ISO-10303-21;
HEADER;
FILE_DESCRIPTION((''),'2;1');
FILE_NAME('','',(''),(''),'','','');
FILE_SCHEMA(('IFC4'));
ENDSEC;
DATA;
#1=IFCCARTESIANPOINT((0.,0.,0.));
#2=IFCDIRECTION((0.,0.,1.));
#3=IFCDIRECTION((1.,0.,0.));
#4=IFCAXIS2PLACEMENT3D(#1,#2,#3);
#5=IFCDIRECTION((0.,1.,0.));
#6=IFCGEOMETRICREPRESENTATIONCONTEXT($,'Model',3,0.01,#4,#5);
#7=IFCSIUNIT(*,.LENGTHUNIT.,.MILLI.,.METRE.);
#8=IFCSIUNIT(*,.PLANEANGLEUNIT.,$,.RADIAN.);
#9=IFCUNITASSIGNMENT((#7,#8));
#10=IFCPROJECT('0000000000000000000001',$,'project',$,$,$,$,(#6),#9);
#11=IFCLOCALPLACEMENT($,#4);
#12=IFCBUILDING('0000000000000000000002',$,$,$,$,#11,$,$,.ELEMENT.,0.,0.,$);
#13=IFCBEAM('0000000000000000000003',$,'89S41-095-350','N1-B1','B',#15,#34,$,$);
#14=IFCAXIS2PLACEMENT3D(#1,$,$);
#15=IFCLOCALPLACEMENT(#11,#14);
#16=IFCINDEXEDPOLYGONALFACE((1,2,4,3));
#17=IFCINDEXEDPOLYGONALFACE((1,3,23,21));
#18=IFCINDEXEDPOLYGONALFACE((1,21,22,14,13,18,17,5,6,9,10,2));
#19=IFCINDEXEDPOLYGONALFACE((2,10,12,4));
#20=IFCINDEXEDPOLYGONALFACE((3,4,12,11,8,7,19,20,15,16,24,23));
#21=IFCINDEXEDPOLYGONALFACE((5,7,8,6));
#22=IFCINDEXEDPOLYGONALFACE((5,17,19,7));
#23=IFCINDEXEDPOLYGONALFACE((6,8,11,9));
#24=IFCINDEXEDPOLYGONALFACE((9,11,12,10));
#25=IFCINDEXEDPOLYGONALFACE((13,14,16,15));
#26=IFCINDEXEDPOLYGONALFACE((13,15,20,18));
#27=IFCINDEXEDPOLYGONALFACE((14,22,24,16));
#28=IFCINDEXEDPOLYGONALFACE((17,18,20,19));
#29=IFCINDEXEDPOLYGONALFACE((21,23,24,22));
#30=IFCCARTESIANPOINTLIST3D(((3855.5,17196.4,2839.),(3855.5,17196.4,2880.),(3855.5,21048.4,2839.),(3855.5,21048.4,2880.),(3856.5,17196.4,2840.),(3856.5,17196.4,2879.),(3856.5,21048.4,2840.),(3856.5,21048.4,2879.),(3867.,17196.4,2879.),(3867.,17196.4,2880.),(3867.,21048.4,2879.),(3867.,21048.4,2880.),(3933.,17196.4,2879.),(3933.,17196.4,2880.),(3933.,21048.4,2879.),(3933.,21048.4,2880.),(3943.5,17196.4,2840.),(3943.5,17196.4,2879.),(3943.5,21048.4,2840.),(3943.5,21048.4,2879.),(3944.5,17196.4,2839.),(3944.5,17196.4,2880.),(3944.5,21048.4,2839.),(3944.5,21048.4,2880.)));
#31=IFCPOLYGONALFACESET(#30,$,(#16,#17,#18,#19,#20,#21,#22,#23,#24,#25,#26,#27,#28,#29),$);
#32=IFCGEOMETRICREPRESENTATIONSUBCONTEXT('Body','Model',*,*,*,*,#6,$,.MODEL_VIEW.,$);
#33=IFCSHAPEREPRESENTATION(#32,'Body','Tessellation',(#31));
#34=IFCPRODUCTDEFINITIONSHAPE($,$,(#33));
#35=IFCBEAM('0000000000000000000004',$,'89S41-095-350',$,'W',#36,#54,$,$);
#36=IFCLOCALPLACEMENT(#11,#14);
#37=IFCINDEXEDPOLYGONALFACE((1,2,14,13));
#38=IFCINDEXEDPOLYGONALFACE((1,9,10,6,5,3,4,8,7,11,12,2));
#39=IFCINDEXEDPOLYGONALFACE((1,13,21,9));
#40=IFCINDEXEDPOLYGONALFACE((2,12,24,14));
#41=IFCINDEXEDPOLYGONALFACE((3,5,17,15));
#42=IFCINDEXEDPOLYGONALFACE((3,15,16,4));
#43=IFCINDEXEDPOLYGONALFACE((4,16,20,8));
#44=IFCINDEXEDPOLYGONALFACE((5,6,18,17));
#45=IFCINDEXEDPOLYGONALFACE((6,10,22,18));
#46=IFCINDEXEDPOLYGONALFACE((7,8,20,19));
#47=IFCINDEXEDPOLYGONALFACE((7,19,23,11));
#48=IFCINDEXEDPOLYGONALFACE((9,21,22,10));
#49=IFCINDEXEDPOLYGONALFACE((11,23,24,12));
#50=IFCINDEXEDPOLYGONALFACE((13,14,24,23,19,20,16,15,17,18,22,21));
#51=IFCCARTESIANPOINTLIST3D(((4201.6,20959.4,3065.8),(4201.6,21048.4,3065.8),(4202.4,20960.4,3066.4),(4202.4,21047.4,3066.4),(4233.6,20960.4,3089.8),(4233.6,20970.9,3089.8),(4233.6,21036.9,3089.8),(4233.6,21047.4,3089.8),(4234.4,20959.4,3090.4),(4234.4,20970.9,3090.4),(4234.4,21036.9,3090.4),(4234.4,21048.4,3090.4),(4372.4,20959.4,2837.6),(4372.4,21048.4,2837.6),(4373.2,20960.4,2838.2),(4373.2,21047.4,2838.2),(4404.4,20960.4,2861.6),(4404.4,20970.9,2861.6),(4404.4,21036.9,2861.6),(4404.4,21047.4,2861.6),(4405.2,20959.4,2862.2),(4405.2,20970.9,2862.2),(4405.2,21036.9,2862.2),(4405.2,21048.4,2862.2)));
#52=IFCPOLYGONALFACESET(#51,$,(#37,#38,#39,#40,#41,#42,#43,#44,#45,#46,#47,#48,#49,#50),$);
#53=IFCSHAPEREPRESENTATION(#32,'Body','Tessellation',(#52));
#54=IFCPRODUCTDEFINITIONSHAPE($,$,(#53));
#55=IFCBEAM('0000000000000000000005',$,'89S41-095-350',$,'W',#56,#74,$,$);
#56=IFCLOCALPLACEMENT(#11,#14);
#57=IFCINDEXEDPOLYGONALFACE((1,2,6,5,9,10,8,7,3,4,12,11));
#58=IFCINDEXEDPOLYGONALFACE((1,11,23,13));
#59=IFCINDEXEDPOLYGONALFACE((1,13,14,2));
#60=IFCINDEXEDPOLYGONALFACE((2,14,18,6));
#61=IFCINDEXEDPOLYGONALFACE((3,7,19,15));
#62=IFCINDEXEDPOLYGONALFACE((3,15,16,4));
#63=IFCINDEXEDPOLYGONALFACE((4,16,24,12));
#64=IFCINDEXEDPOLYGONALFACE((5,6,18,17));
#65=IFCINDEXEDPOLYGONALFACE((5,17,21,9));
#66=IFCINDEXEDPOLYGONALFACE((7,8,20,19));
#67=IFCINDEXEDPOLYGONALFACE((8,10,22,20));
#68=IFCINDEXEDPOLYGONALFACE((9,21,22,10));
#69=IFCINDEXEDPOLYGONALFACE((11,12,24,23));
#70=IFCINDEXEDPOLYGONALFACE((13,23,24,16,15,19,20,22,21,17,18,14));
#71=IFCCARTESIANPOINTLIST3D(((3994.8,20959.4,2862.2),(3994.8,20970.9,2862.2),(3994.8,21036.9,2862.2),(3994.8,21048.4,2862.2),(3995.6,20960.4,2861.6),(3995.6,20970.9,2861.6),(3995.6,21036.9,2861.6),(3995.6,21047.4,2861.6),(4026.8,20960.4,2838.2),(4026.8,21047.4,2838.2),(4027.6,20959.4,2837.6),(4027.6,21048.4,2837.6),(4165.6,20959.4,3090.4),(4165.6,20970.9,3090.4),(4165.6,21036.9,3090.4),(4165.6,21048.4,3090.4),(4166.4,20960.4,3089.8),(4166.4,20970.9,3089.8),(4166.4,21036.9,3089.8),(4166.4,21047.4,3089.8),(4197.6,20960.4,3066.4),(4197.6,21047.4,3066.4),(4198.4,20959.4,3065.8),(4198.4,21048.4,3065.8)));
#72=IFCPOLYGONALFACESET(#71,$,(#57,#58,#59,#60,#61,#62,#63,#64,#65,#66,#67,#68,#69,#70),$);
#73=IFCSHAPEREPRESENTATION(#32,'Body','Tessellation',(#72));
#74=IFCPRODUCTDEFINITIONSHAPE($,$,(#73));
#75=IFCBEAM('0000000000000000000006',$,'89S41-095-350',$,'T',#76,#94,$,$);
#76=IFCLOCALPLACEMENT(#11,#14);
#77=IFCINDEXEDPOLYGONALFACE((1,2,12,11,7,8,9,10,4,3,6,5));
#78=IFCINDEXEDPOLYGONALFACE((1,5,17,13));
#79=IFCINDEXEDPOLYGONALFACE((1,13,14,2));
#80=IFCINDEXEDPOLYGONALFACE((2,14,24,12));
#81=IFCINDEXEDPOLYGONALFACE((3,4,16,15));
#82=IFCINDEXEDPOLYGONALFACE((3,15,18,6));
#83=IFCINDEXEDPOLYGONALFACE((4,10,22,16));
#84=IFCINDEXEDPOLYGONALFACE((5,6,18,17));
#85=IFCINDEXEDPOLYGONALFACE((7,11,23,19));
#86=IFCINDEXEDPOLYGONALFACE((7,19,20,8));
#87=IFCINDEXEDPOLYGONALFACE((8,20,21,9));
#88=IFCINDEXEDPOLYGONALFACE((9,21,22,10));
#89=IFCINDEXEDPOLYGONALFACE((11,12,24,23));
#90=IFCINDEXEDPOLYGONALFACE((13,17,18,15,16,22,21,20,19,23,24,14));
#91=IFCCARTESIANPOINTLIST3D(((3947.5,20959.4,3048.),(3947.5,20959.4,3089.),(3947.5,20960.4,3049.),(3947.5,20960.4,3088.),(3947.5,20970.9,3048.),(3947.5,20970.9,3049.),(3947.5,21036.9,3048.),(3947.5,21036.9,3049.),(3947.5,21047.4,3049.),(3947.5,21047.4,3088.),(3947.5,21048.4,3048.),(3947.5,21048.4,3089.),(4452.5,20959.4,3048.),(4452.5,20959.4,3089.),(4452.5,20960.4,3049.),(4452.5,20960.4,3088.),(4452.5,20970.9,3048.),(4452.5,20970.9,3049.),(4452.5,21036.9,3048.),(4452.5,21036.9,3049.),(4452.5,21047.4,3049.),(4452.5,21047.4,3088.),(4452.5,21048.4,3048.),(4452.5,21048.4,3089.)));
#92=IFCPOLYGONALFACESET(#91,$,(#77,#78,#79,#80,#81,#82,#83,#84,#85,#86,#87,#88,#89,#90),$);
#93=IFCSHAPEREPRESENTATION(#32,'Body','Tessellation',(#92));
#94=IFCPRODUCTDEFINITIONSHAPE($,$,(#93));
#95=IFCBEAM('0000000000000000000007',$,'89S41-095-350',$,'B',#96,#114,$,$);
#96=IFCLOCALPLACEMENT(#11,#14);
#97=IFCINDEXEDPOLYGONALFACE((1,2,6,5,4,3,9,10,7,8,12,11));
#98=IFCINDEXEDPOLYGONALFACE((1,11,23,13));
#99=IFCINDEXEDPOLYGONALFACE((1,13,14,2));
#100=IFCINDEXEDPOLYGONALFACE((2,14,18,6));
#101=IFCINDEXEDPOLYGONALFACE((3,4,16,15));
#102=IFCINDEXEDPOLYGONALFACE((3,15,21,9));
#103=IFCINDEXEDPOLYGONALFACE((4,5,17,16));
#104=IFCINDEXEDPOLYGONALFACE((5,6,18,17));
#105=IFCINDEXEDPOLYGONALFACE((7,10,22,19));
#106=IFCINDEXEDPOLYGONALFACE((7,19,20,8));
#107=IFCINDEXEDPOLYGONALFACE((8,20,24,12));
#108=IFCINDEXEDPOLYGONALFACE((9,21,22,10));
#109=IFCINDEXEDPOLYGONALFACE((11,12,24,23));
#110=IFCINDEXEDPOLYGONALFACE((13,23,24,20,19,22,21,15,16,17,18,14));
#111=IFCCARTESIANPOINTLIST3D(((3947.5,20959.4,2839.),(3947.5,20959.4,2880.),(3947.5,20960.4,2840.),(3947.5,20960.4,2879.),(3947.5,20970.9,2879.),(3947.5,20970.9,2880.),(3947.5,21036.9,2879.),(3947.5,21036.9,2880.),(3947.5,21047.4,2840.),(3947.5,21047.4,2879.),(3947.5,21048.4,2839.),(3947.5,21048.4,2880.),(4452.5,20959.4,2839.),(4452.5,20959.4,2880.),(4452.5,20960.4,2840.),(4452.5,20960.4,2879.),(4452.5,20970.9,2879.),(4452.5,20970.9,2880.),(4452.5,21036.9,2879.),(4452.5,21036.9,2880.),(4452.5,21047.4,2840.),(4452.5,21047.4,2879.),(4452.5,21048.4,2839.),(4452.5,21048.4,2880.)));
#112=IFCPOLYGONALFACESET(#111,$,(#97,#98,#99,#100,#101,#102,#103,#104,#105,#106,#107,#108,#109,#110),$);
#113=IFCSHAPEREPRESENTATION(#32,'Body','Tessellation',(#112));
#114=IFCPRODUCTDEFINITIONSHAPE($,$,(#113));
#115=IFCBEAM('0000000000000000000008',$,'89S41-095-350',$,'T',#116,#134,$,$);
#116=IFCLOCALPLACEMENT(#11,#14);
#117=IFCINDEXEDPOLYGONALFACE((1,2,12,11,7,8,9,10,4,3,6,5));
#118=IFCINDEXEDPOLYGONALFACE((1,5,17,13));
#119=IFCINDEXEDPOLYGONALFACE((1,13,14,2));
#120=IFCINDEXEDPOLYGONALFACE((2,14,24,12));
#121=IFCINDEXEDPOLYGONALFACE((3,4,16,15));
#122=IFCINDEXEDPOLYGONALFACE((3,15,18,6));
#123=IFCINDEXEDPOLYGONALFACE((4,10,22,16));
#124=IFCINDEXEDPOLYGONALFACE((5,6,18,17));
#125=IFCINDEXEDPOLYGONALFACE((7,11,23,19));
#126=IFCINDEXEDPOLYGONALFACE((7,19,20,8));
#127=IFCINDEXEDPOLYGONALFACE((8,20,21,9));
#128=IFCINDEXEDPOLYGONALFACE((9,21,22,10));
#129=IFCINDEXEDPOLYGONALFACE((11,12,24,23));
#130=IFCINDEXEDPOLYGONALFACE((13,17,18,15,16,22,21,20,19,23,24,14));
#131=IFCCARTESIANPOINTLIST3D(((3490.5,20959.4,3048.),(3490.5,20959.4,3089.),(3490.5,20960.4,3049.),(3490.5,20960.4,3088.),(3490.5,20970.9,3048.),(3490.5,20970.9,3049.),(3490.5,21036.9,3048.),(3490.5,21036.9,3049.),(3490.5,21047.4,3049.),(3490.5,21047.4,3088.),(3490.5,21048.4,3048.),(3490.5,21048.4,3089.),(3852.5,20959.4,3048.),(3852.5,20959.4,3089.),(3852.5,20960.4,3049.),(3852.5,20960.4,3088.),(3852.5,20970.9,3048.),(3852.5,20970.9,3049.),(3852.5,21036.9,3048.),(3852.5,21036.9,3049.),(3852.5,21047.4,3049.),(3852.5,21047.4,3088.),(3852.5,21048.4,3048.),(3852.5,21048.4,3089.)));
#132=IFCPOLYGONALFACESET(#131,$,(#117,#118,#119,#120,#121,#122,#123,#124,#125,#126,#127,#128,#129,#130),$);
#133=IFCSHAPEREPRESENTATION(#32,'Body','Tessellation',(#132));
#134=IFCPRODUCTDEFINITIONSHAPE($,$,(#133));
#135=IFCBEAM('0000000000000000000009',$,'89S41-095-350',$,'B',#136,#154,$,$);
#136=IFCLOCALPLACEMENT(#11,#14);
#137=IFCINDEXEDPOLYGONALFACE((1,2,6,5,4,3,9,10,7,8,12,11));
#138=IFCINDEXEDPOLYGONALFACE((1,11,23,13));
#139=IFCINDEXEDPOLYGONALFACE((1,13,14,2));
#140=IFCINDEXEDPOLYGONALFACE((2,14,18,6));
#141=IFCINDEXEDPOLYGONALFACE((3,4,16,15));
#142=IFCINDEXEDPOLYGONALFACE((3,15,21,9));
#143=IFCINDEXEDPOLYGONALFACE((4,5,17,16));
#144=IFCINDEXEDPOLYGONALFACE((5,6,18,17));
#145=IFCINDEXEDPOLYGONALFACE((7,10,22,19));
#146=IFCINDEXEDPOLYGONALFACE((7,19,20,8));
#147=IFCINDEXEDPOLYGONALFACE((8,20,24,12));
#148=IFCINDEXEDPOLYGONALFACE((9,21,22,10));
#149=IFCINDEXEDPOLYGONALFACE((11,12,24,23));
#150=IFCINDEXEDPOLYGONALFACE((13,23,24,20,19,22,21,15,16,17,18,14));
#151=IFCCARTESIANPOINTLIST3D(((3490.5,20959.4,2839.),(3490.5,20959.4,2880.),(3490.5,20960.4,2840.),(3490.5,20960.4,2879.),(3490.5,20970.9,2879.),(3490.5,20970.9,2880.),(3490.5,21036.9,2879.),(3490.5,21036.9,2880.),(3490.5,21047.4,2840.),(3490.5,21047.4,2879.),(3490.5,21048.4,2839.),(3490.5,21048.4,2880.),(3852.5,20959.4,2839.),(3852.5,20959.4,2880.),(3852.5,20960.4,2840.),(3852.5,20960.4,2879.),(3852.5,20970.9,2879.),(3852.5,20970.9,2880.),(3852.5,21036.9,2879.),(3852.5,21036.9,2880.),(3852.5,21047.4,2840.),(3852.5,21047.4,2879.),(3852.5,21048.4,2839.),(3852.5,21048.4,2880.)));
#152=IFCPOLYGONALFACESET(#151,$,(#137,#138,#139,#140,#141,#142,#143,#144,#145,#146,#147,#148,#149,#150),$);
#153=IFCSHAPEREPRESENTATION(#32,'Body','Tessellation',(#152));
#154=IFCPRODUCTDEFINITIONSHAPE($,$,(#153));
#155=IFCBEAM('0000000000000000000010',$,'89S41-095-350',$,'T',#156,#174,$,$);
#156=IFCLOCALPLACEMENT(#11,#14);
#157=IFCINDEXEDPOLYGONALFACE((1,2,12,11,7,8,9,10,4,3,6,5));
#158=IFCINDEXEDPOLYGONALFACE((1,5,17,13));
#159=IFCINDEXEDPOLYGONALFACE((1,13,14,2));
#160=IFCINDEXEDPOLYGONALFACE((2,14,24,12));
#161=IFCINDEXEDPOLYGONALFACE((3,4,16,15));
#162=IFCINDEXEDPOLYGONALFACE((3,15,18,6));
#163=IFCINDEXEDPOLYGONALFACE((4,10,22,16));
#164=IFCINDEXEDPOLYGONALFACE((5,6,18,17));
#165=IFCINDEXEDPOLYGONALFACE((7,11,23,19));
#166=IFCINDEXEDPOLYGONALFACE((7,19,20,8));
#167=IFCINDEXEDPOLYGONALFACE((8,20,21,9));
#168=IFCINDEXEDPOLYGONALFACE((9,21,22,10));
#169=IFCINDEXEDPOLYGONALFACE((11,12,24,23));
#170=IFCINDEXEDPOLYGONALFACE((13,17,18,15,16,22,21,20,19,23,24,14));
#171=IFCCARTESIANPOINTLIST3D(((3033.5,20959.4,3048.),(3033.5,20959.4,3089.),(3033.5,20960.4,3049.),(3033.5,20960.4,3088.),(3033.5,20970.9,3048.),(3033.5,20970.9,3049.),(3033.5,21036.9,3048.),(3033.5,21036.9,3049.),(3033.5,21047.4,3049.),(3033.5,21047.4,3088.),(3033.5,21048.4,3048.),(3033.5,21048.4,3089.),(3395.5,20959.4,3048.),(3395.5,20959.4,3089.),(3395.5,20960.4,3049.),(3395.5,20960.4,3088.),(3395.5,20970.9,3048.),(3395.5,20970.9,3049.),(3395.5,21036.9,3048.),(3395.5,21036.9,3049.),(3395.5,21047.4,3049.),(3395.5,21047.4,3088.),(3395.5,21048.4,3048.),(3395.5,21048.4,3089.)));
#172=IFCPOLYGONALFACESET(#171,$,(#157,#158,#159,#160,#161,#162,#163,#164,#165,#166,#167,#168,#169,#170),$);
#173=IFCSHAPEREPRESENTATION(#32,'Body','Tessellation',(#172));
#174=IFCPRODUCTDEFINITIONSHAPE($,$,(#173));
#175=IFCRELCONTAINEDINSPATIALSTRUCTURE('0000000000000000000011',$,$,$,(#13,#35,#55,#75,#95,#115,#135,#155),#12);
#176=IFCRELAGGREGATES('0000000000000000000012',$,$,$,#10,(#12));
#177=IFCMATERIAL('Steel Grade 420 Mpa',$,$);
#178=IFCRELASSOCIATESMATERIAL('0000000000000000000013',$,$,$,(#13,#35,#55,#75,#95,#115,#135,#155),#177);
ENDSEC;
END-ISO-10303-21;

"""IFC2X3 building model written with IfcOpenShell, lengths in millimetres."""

from ifc_helpers import new_model, si_unit, direction, frame, origin, origin_with_axes, origin_2d_with_axis, place, context, subcontext, project, spatial, c_section, extrude, source, transform, mapped, material, element, save


model = new_model("IFC2X3")

# Units and contexts
model_context = context("Model", 3, precision=0.01, world=origin_with_axes(), true_north=direction((0.0, 1.0, 0.0)))
body_context = subcontext(model_context, "Body", "Model", "MODEL_VIEW")
ifc_project = project(units=[si_unit("LENGTHUNIT", "METRE", prefix="MILLI"), si_unit("PLANEANGLEUNIT", "RADIAN")], contexts=[model_context])

# Building
building_placement = place(None, origin_with_axes())
building = spatial("IfcBuilding", under=ifc_project, at=building_placement, CompositionType="ELEMENT", ElevationOfRefHeight=0.0, ElevationOfTerrain=0.0)

# Shared definitions
ifc_material = material(Name="Steel Grade 420 Mpa")

# Beams
shared_shape_1 = source(origin(), body_context, "Body", "SweptSolid", [
    extrude(c_section(Depth=89.0, Width=41.0, WallThickness=1.0, Girth=11.5, at=origin_2d_with_axis()), origin_with_axes(), (0.0, 0.0, 1.0), 3852.0),
])
beam_1_placement = place(None, frame((3900.0, 21048.4, 2859.5), z_axis=(0.0, -1.0, 0.0), x_axis=(0.0, 0.0, 1.0)))
element("IfcBeam", 1, at=beam_1_placement, inside=building, material=ifc_material, Name="89S41-095-350", Description="N1-B1", ObjectType="B", context=body_context, shape_type="MappedRepresentation", body=[
    mapped(shared_shape_1, transform((0.0, 0.0, 0.0), scale=1.0)),
])
shared_shape_2 = source(origin(), body_context, "Body", "SweptSolid", [
    extrude(c_section(Depth=89.0, Width=41.0, WallThickness=1.0, Girth=11.5, at=origin_2d_with_axis()), origin_with_axes(), (0.0, 0.0, 1.0), 285.1),
])
beam_2_placement = place(None, frame((4218.0, 21003.9, 3078.1), z_axis=(0.599182, 0.0, -0.800613), x_axis=(0.800613, 0.0, 0.599182)))
element("IfcBeam", 2, at=beam_2_placement, inside=building, material=ifc_material, Name="89S41-095-350", ObjectType="W", context=body_context, shape_type="MappedRepresentation", body=[
    mapped(shared_shape_2, transform((0.0, 0.0, 0.0), scale=1.0)),
])
shared_shape_3 = source(origin(), body_context, "Body", "SweptSolid", [
    extrude(c_section(Depth=89.0, Width=41.0, WallThickness=1.0, Girth=11.5, at=origin_2d_with_axis()), origin_with_axes(), (0.0, 0.0, 1.0), 285.1),
])
beam_3_placement = place(None, frame((4011.2, 21003.9, 2849.9), z_axis=(0.599182, 0.0, 0.800613), x_axis=(-0.800613, 0.0, 0.599182)))
element("IfcBeam", 3, at=beam_3_placement, inside=building, material=ifc_material, Name="89S41-095-350", ObjectType="W", context=body_context, shape_type="MappedRepresentation", body=[
    mapped(shared_shape_3, transform((0.0, 0.0, 0.0), scale=1.0)),
])
shared_shape_4 = source(origin(), body_context, "Body", "SweptSolid", [
    extrude(c_section(Depth=89.0, Width=41.0, WallThickness=1.0, Girth=11.5, at=origin_2d_with_axis()), origin_with_axes(), (0.0, 0.0, 1.0), 505.0),
])
beam_4_placement = place(None, frame((4452.5, 21003.9, 3068.5), z_axis=(-1.0, 0.0, 0.0), x_axis=(0.0, 0.0, -1.0)))
element("IfcBeam", 4, at=beam_4_placement, inside=building, material=ifc_material, Name="89S41-095-350", ObjectType="T", context=body_context, shape_type="MappedRepresentation", body=[
    mapped(shared_shape_4, transform((0.0, 0.0, 0.0), scale=1.0)),
])
shared_shape_5 = source(origin(), body_context, "Body", "SweptSolid", [
    extrude(c_section(Depth=89.0, Width=41.0, WallThickness=1.0, Girth=11.5, at=origin_2d_with_axis()), origin_with_axes(), (0.0, 0.0, 1.0), 505.0),
])
beam_5_placement = place(None, frame((3947.5, 21003.9, 2859.5), z_axis=(1.0, 0.0, 0.0), x_axis=(0.0, 0.0, 1.0)))
element("IfcBeam", 5, at=beam_5_placement, inside=building, material=ifc_material, Name="89S41-095-350", ObjectType="B", context=body_context, shape_type="MappedRepresentation", body=[
    mapped(shared_shape_5, transform((0.0, 0.0, 0.0), scale=1.0)),
])
shared_shape_6 = source(origin(), body_context, "Body", "SweptSolid", [
    extrude(c_section(Depth=89.0, Width=41.0, WallThickness=1.0, Girth=11.5, at=origin_2d_with_axis()), origin_with_axes(), (0.0, 0.0, 1.0), 362.0),
])
beam_6_placement = place(None, frame((3852.5, 21003.9, 3068.5), z_axis=(-1.0, 0.0, 0.0), x_axis=(0.0, 0.0, -1.0)))
element("IfcBeam", 6, at=beam_6_placement, inside=building, material=ifc_material, Name="89S41-095-350", ObjectType="T", context=body_context, shape_type="MappedRepresentation", body=[
    mapped(shared_shape_6, transform((0.0, 0.0, 0.0), scale=1.0)),
])
shared_shape_7 = source(origin(), body_context, "Body", "SweptSolid", [
    extrude(c_section(Depth=89.0, Width=41.0, WallThickness=1.0, Girth=11.5, at=origin_2d_with_axis()), origin_with_axes(), (0.0, 0.0, 1.0), 362.0),
])
beam_7_placement = place(None, frame((3490.5, 21003.9, 2859.5), z_axis=(1.0, 0.0, 0.0), x_axis=(0.0, 0.0, 1.0)))
element("IfcBeam", 7, at=beam_7_placement, inside=building, material=ifc_material, Name="89S41-095-350", ObjectType="B", context=body_context, shape_type="MappedRepresentation", body=[
    mapped(shared_shape_7, transform((0.0, 0.0, 0.0), scale=1.0)),
])
shared_shape_8 = source(origin(), body_context, "Body", "SweptSolid", [
    extrude(c_section(Depth=89.0, Width=41.0, WallThickness=1.0, Girth=11.5, at=origin_2d_with_axis()), origin_with_axes(), (0.0, 0.0, 1.0), 362.0),
])
beam_8_placement = place(None, frame((3395.5, 21003.9, 3068.5), z_axis=(-1.0, 0.0, 0.0), x_axis=(0.0, 0.0, -1.0)))
element("IfcBeam", 8, at=beam_8_placement, inside=building, material=ifc_material, Name="89S41-095-350", ObjectType="T", context=body_context, shape_type="MappedRepresentation", body=[
    mapped(shared_shape_8, transform((0.0, 0.0, 0.0), scale=1.0)),
])

save(model, "model.ifc")
